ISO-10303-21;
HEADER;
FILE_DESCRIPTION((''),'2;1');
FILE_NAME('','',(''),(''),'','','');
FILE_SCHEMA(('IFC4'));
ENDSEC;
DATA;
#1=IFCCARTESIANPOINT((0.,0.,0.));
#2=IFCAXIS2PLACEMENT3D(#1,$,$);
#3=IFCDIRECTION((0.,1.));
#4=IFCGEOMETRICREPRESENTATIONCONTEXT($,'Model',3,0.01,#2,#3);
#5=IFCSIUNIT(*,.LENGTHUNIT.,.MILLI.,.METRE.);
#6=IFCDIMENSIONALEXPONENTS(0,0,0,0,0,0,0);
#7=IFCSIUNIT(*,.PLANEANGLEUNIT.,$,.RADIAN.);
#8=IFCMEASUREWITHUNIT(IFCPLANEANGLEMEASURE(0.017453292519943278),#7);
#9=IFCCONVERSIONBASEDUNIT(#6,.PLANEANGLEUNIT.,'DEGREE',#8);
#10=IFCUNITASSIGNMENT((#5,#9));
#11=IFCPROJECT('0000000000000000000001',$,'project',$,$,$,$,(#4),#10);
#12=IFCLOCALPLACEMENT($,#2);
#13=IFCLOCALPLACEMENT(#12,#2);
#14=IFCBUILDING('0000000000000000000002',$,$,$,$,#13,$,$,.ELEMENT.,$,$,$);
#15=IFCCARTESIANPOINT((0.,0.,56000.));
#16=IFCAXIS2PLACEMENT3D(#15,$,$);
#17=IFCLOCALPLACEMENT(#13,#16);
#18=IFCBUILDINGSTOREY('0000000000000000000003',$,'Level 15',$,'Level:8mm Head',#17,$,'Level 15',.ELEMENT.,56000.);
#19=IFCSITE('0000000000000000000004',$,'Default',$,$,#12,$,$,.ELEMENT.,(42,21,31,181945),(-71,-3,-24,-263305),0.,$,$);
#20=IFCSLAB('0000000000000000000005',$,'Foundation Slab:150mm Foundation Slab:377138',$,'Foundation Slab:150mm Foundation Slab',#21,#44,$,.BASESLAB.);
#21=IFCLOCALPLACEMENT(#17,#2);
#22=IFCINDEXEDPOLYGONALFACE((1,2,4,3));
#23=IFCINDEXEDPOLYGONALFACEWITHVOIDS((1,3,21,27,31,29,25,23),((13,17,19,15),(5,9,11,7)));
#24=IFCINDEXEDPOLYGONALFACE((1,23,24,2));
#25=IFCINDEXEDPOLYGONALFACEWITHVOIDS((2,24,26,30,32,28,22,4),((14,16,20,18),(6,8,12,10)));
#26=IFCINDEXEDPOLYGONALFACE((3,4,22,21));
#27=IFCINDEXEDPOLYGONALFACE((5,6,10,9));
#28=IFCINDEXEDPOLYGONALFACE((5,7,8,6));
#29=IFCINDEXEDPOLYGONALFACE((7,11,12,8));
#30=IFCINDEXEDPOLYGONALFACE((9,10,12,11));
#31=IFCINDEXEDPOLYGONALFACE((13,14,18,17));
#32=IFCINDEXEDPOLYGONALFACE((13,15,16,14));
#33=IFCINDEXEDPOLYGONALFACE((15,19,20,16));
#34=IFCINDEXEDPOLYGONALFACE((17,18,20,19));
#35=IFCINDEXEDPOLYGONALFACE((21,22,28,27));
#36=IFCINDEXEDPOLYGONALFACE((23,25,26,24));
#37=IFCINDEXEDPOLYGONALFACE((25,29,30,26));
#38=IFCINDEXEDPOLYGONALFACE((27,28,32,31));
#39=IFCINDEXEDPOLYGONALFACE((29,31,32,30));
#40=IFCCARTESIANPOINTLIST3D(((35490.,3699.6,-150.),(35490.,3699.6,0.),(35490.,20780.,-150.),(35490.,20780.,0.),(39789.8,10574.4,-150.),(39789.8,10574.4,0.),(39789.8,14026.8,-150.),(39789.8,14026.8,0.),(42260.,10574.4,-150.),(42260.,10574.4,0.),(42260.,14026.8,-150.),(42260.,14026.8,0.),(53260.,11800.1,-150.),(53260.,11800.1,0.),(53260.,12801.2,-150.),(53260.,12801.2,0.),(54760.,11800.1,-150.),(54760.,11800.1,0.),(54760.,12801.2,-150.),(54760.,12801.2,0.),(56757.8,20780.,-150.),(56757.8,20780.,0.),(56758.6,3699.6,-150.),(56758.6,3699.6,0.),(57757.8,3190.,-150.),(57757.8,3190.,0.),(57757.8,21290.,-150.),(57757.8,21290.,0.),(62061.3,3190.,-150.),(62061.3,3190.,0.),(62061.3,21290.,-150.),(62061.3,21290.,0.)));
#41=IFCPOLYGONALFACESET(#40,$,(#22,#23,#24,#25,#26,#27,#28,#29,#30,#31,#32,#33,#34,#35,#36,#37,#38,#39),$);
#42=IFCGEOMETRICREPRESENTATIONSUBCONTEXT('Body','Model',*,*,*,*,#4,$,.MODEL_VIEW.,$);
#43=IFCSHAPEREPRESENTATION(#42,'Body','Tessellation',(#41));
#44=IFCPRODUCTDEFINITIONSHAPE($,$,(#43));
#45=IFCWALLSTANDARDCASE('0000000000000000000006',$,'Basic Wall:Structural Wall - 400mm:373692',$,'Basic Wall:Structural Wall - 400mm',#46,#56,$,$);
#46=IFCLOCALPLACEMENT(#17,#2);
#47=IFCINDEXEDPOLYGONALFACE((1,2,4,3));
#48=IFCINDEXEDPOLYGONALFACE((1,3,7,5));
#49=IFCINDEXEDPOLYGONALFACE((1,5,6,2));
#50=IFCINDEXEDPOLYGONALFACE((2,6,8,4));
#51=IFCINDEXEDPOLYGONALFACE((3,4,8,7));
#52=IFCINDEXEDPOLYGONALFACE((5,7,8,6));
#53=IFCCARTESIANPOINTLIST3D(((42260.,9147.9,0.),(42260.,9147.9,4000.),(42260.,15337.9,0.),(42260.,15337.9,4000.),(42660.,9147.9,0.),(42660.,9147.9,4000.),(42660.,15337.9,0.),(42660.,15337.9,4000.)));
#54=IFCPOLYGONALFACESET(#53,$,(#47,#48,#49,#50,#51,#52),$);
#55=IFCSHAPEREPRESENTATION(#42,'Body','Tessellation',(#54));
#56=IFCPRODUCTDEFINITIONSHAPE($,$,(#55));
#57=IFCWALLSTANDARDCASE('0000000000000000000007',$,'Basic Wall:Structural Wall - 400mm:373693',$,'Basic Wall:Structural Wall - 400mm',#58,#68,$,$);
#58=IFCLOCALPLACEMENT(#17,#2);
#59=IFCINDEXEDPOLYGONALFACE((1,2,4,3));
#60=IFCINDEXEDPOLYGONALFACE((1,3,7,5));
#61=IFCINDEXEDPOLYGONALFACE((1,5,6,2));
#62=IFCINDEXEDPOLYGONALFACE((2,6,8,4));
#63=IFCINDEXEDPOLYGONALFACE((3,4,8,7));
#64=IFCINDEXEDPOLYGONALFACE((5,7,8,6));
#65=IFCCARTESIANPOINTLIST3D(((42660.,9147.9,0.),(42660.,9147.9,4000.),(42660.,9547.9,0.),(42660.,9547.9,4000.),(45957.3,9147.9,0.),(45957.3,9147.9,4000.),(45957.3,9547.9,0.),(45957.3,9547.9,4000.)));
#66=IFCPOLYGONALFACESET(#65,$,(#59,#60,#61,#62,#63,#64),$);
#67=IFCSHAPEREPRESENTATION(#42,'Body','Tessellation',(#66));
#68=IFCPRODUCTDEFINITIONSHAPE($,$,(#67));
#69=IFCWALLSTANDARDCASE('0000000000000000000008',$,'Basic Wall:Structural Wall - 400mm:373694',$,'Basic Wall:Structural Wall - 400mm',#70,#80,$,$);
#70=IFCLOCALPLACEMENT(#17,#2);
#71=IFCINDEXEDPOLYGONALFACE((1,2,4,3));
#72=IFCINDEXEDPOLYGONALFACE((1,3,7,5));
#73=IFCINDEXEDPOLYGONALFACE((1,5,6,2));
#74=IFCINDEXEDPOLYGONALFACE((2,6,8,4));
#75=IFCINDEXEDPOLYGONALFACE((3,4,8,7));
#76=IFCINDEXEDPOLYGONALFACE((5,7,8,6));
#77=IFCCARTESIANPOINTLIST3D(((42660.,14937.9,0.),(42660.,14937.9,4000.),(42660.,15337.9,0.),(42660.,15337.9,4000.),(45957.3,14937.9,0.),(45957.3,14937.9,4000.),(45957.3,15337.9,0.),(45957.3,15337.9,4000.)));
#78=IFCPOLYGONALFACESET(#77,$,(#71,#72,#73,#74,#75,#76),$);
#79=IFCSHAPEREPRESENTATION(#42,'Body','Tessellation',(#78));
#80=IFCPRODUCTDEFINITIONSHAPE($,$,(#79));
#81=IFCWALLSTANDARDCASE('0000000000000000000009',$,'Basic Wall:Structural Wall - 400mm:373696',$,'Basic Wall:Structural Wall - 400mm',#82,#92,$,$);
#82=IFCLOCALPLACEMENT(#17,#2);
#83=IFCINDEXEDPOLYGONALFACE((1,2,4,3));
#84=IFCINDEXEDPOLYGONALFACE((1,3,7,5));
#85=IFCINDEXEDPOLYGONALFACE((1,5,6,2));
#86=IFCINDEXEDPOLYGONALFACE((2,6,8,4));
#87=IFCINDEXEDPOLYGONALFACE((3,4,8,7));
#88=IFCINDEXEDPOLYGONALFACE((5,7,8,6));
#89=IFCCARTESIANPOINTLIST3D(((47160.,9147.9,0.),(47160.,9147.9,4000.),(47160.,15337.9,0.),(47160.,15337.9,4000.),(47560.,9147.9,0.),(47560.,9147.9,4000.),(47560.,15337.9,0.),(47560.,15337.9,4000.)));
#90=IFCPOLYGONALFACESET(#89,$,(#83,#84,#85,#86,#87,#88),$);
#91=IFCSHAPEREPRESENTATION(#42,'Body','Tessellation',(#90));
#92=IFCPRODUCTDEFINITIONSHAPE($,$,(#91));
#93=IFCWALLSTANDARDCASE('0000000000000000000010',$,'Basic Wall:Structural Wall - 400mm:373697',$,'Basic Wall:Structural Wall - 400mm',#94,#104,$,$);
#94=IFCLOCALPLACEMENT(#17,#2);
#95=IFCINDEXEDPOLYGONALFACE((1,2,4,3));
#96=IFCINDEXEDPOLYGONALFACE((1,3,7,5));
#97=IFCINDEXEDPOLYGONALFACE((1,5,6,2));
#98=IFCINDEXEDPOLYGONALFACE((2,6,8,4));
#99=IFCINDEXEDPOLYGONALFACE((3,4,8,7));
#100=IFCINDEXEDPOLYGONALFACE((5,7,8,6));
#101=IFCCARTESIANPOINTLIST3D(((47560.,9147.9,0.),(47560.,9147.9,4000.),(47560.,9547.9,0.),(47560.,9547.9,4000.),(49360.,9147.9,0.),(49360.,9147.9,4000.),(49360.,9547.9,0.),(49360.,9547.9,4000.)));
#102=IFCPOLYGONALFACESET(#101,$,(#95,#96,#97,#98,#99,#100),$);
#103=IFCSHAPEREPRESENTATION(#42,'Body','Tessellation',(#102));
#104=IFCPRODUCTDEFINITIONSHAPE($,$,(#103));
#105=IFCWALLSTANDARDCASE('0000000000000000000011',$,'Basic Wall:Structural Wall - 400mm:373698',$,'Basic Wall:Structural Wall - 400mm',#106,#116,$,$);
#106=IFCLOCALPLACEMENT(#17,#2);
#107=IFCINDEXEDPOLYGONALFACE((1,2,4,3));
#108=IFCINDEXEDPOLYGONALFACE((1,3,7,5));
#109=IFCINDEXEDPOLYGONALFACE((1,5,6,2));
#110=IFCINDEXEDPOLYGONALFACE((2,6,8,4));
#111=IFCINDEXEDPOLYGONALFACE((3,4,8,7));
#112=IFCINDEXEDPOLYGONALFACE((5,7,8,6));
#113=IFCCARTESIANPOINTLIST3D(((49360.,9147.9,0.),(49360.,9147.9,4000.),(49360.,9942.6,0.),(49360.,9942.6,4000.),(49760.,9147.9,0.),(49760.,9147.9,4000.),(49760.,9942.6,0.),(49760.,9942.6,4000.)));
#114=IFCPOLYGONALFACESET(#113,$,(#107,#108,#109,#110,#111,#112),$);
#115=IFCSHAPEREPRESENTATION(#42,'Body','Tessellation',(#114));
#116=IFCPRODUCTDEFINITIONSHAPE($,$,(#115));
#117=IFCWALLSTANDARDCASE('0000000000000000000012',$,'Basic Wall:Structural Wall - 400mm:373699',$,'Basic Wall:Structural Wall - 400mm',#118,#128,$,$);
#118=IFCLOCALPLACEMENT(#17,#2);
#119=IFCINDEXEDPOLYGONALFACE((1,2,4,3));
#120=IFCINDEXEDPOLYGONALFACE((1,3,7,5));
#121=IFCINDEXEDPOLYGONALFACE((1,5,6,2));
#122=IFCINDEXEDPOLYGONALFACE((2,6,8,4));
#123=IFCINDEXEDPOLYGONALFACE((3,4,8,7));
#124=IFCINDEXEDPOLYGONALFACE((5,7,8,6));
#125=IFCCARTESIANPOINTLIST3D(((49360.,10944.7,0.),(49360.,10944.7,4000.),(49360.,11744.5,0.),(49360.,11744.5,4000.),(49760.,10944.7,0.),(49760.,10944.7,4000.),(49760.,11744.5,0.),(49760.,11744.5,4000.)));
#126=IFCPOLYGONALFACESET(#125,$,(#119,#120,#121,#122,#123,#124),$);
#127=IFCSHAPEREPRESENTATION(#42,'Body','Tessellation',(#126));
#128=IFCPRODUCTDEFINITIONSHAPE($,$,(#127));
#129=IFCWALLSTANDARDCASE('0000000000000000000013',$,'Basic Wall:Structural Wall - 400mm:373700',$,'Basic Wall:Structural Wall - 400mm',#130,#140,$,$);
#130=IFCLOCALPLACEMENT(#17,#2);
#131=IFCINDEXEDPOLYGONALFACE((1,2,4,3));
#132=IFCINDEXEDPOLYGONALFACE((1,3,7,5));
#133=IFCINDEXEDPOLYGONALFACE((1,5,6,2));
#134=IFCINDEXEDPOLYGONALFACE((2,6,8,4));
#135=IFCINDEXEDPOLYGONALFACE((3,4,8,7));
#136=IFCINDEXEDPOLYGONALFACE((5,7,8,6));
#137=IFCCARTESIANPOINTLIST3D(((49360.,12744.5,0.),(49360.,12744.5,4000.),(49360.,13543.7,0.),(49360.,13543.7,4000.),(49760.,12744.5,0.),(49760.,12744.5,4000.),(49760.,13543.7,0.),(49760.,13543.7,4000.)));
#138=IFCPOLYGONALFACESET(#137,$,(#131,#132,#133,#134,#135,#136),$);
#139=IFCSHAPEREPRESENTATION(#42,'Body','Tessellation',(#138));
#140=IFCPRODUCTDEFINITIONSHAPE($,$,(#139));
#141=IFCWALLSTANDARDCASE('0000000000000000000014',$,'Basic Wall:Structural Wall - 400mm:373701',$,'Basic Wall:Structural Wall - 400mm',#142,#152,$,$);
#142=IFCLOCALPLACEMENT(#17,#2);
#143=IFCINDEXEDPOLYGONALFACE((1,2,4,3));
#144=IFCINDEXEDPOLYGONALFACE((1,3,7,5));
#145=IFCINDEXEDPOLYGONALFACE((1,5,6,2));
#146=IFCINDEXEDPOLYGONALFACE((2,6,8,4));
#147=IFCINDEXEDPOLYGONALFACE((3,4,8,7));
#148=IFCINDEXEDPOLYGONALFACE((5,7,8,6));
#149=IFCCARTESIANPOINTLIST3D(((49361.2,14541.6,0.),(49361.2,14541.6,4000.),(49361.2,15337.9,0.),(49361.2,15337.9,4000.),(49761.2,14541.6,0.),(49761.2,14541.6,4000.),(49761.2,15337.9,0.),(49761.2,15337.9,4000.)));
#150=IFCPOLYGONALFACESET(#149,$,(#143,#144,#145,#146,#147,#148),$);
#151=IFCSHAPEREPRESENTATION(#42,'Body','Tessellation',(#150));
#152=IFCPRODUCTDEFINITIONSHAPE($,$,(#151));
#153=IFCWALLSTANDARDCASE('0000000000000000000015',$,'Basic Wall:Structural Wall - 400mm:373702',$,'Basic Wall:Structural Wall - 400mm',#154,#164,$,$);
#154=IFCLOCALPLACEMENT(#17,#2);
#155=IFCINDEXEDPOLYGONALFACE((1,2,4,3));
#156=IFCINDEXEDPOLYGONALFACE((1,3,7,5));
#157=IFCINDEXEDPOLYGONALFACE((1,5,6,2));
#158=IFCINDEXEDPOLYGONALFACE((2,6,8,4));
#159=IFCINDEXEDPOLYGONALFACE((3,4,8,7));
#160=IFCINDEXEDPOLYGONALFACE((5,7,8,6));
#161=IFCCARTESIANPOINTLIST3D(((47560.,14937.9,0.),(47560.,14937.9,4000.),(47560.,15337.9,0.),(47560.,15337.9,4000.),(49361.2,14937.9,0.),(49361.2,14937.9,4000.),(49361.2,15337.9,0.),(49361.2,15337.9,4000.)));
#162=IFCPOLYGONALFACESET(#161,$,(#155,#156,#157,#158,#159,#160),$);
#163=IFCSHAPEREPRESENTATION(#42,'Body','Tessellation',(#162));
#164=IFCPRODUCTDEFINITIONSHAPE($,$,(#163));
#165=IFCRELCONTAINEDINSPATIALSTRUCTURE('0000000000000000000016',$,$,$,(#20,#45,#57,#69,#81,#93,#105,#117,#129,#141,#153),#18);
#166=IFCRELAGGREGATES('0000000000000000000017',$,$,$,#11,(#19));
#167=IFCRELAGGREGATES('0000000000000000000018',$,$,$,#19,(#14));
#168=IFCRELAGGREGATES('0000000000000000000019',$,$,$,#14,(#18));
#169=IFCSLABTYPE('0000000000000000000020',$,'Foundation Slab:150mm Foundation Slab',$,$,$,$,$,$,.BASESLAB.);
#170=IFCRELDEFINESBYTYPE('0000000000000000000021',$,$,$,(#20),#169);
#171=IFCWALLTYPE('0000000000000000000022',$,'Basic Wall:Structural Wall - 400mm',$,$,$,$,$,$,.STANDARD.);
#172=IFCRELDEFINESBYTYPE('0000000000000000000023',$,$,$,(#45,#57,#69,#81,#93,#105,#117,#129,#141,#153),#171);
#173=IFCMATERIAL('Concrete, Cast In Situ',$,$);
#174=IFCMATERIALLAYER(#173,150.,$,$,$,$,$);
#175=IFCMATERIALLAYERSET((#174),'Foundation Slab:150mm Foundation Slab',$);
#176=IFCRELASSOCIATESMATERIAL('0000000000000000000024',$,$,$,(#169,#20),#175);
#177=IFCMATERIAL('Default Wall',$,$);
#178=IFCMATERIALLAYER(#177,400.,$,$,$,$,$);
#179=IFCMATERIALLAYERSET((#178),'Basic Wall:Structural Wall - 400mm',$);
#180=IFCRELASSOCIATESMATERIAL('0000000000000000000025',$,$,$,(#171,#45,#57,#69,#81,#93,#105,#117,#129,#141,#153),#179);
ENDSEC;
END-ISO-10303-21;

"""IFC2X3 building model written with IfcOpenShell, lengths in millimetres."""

from ifc_helpers import new_model, entity, si_unit, converted_unit, direction, frame, frame_2d, origin, place, context, subcontext, project, spatial, polyline, rectangle, outline, extrude, boolean, material, layer, layer_set, layer_usage, type_object, element, save


model = new_model("IFC2X3")

# Units and contexts
model_context = context("Model", 3, precision=0.01, world=origin(), true_north=direction((0.0, 1.0)))
body_context = subcontext(model_context, "Body", "Model", "MODEL_VIEW")
ifc_project = project(units=[si_unit("LENGTHUNIT", "METRE", prefix="MILLI"), converted_unit("PLANEANGLEUNIT", "DEGREE", entity("IfcPlaneAngleMeasure", 0.017453292519943278), si_unit("PLANEANGLEUNIT", "RADIAN"), dimensions=[0, 0, 0, 0, 0, 0, 0])], contexts=[model_context])

# Site, building, storey
site_placement = place(None, origin())
site = spatial("IfcSite", under=ifc_project, at=site_placement, Name="Default", CompositionType="ELEMENT", RefLatitude=(42, 21, 31, 181945), RefLongitude=(-71, -3, -24, -263305), RefElevation=0.0)
building_placement = place(site_placement, origin())
building = spatial("IfcBuilding", under=site, at=building_placement, CompositionType="ELEMENT")
storey_placement = place(building_placement, frame((0.0, 0.0, 56000.0)))
storey = spatial("IfcBuildingStorey", under=building, at=storey_placement, Name="Level 15", ObjectType="Level:8mm Head", LongName="Level 15", CompositionType="ELEMENT", Elevation=56000.0)

# Slab, openings
ifc_material_1 = material(Name="Concrete, Cast In Situ")
ifc_layer_1 = layer(ifc_material_1, 150.0)
ifc_layer_set_1 = layer_set([ifc_layer_1], Name="Foundation Slab:150mm Foundation Slab")
ifc_layer_usage_1 = layer_usage(ifc_layer_set_1, "AXIS3", "POSITIVE", 0.0)
slab_type = type_object("IfcSlabType", Name="Foundation Slab:150mm Foundation Slab", PredefinedType="BASESLAB", material=ifc_layer_set_1)
slab_placement = place(storey_placement, origin())
slab = element("IfcSlab", 1, at=slab_placement, inside=storey, type_object=slab_type, material=ifc_layer_usage_1, Name="Foundation Slab:150mm Foundation Slab:377138", ObjectType="Foundation Slab:150mm Foundation Slab", PredefinedType="BASESLAB", context=body_context, shape_type="CSG", body=[
    boolean("DIFFERENCE", boolean("DIFFERENCE", extrude(outline(polyline([(-8540.3, -17526.8), (8540.1, -17526.8), (8540.1, 3741.0), (9050.1, 4741.0), (9050.1, 9044.5), (-9049.9, 9044.5), (-9049.9, 4741.0), (-8540.3, 3741.8), (-8540.3, -17526.8)])), frame((53016.8, 12239.9, 0.0), z_axis=(0.0, 0.0, -1.0), x_axis=(0.0, 1.0, 0.0)), (0.0, 0.0, 1.0), 150.0), extrude(rectangle(XDim=3452.5, YDim=2470.2, at=frame_2d((0.0, 0.0), x_axis=(1.0, 0.0))), frame((41024.9, 12300.6, -150.0), z_axis=(0.0, 0.0, 1.0), x_axis=(0.0, 1.0, 0.0)), (0.0, 0.0, 1.0), 150.0)), extrude(rectangle(XDim=1001.2, YDim=1500.1, at=frame_2d((0.0, 0.0), x_axis=(1.0, 0.0))), frame((54010.0, 12300.6, -150.0), z_axis=(0.0, 0.0, 1.0), x_axis=(0.0, 1.0, 0.0)), (0.0, 0.0, 1.0), 150.0)),
])
opening_1_placement = place(slab_placement, origin())
element("IfcOpeningElement", 2, at=opening_1_placement, cuts=slab, ObjectType="Opening", context=body_context, shape_type="SweptSolid", body=[
    extrude(rectangle(XDim=3452.5, YDim=2470.2, at=frame_2d((41024.9, 12300.6), x_axis=(0.0, -1.0))), origin(), (0.0, 0.0, -1.0), 150.0),
])
opening_2_placement = place(slab_placement, origin())
element("IfcOpeningElement", 3, at=opening_2_placement, cuts=slab, ObjectType="Opening", context=body_context, shape_type="SweptSolid", body=[
    extrude(rectangle(XDim=1500.1, YDim=1001.2, at=frame_2d((54010.0, 12300.6), x_axis=(-1.0, 0.0))), origin(), (0.0, 0.0, -1.0), 150.0),
])

# Walls
ifc_material_2 = material(Name="Default Wall")
ifc_layer_2 = layer(ifc_material_2, 400.0)
ifc_layer_set_2 = layer_set([ifc_layer_2], Name="Basic Wall:Structural Wall - 400mm")
ifc_layer_usage_2 = layer_usage(ifc_layer_set_2, "AXIS2", "POSITIVE", -200.0)
wall_type_1 = type_object("IfcWallType", Name="Basic Wall:Structural Wall - 400mm", PredefinedType="STANDARD", material=ifc_layer_set_2)
wall_1_placement = place(storey_placement, frame((42460.0, 15337.9, 0.0), z_axis=(0.0, 0.0, 1.0), x_axis=(0.0, -1.0, 0.0)))
element("IfcWallStandardCase", 4, at=wall_1_placement, inside=storey, type_object=wall_type_1, material=ifc_layer_usage_2, Name="Basic Wall:Structural Wall - 400mm:373692", ObjectType="Basic Wall:Structural Wall - 400mm", context=body_context, shape_type="SweptSolid", body=[
    extrude(rectangle(XDim=6190.0, YDim=400.0, at=frame_2d((3095.0, 0.0), x_axis=(-1.0, 0.0))), origin(), (0.0, 0.0, 1.0), 4000.0),
])
ifc_layer_usage_3 = layer_usage(ifc_layer_set_2, "AXIS2", "POSITIVE", -200.0)
wall_2_placement = place(storey_placement, frame((42660.0, 9347.9, 0.0)))
element("IfcWallStandardCase", 5, at=wall_2_placement, inside=storey, type_object=wall_type_1, material=ifc_layer_usage_3, Name="Basic Wall:Structural Wall - 400mm:373693", ObjectType="Basic Wall:Structural Wall - 400mm", context=body_context, shape_type="SweptSolid", body=[
    extrude(rectangle(XDim=3297.3, YDim=400.0, at=frame_2d((1648.6, 0.0), x_axis=(-1.0, 0.0))), origin(), (0.0, 0.0, 1.0), 4000.0),
])
ifc_layer_usage_4 = layer_usage(ifc_layer_set_2, "AXIS2", "POSITIVE", -200.0)
wall_3_placement = place(storey_placement, frame((45957.3, 15137.9, 0.0), z_axis=(0.0, 0.0, 1.0), x_axis=(-1.0, 0.0, 0.0)))
element("IfcWallStandardCase", 6, at=wall_3_placement, inside=storey, type_object=wall_type_1, material=ifc_layer_usage_4, Name="Basic Wall:Structural Wall - 400mm:373694", ObjectType="Basic Wall:Structural Wall - 400mm", context=body_context, shape_type="SweptSolid", body=[
    extrude(rectangle(XDim=3297.3, YDim=400.0, at=frame_2d((1648.6, 0.0), x_axis=(-1.0, 0.0))), origin(), (0.0, 0.0, 1.0), 4000.0),
])
ifc_layer_usage_5 = layer_usage(ifc_layer_set_2, "AXIS2", "POSITIVE", -200.0)
wall_4_placement = place(storey_placement, frame((47360.0, 15337.9, 0.0), z_axis=(0.0, 0.0, 1.0), x_axis=(0.0, -1.0, 0.0)))
element("IfcWallStandardCase", 7, at=wall_4_placement, inside=storey, type_object=wall_type_1, material=ifc_layer_usage_5, Name="Basic Wall:Structural Wall - 400mm:373696", ObjectType="Basic Wall:Structural Wall - 400mm", context=body_context, shape_type="SweptSolid", body=[
    extrude(rectangle(XDim=6190.0, YDim=400.0, at=frame_2d((3095.0, 0.0), x_axis=(-1.0, 0.0))), origin(), (0.0, 0.0, 1.0), 4000.0),
])
ifc_layer_usage_6 = layer_usage(ifc_layer_set_2, "AXIS2", "POSITIVE", -200.0)
wall_5_placement = place(storey_placement, frame((47560.0, 9347.9, 0.0)))
element("IfcWallStandardCase", 8, at=wall_5_placement, inside=storey, type_object=wall_type_1, material=ifc_layer_usage_6, Name="Basic Wall:Structural Wall - 400mm:373697", ObjectType="Basic Wall:Structural Wall - 400mm", context=body_context, shape_type="SweptSolid", body=[
    extrude(rectangle(XDim=1800.0, YDim=400.0, at=frame_2d((900.0, 0.0), x_axis=(-1.0, 0.0))), origin(), (0.0, 0.0, 1.0), 4000.0),
])
ifc_layer_usage_7 = layer_usage(ifc_layer_set_2, "AXIS2", "NEGATIVE", 200.0)
wall_6_placement = place(storey_placement, frame((49560.0, 9147.9, 0.0), z_axis=(0.0, 0.0, 1.0), x_axis=(0.0, 1.0, 0.0)))
element("IfcWallStandardCase", 9, at=wall_6_placement, inside=storey, type_object=wall_type_1, material=ifc_layer_usage_7, Name="Basic Wall:Structural Wall - 400mm:373698", ObjectType="Basic Wall:Structural Wall - 400mm", context=body_context, shape_type="SweptSolid", body=[
    extrude(rectangle(XDim=794.7, YDim=400.0, at=frame_2d((397.3, 0.0), x_axis=(-1.0, 0.0))), origin(), (0.0, 0.0, 1.0), 4000.0),
])
ifc_layer_usage_8 = layer_usage(ifc_layer_set_2, "AXIS2", "POSITIVE", -200.0)
wall_7_placement = place(storey_placement, frame((49560.0, 10944.7, 0.0), z_axis=(0.0, 0.0, 1.0), x_axis=(0.0, 1.0, 0.0)))
element("IfcWallStandardCase", 10, at=wall_7_placement, inside=storey, type_object=wall_type_1, material=ifc_layer_usage_8, Name="Basic Wall:Structural Wall - 400mm:373699", ObjectType="Basic Wall:Structural Wall - 400mm", context=body_context, shape_type="SweptSolid", body=[
    extrude(rectangle(XDim=799.8, YDim=400.0, at=frame_2d((399.9, 0.0), x_axis=(-1.0, 0.0))), origin(), (0.0, 0.0, 1.0), 4000.0),
])
ifc_layer_usage_9 = layer_usage(ifc_layer_set_2, "AXIS2", "POSITIVE", -200.0)
wall_8_placement = place(storey_placement, frame((49560.0, 12744.5, 0.0), z_axis=(0.0, 0.0, 1.0), x_axis=(0.0, 1.0, 0.0)))
element("IfcWallStandardCase", 11, at=wall_8_placement, inside=storey, type_object=wall_type_1, material=ifc_layer_usage_9, Name="Basic Wall:Structural Wall - 400mm:373700", ObjectType="Basic Wall:Structural Wall - 400mm", context=body_context, shape_type="SweptSolid", body=[
    extrude(rectangle(XDim=799.2, YDim=400.0, at=frame_2d((399.6, 0.0), x_axis=(-1.0, 0.0))), origin(), (0.0, 0.0, 1.0), 4000.0),
])
ifc_layer_usage_10 = layer_usage(ifc_layer_set_2, "AXIS2", "POSITIVE", -200.0)
wall_9_placement = place(storey_placement, frame((49561.2, 14541.6, 0.0), z_axis=(0.0, 0.0, 1.0), x_axis=(0.0, 1.0, 0.0)))
element("IfcWallStandardCase", 12, at=wall_9_placement, inside=storey, type_object=wall_type_1, material=ifc_layer_usage_10, Name="Basic Wall:Structural Wall - 400mm:373701", ObjectType="Basic Wall:Structural Wall - 400mm", context=body_context, shape_type="SweptSolid", body=[
    extrude(rectangle(XDim=796.3, YDim=400.0, at=frame_2d((398.2, 0.0), x_axis=(-1.0, 0.0))), origin(), (0.0, 0.0, 1.0), 4000.0),
])
ifc_layer_usage_11 = layer_usage(ifc_layer_set_2, "AXIS2", "POSITIVE", -200.0)
wall_10_placement = place(storey_placement, frame((49361.2, 15137.9, 0.0), z_axis=(0.0, 0.0, 1.0), x_axis=(-1.0, 0.0, 0.0)))
element("IfcWallStandardCase", 13, at=wall_10_placement, inside=storey, type_object=wall_type_1, material=ifc_layer_usage_11, Name="Basic Wall:Structural Wall - 400mm:373702", ObjectType="Basic Wall:Structural Wall - 400mm", context=body_context, shape_type="SweptSolid", body=[
    extrude(rectangle(XDim=1801.2, YDim=400.0, at=frame_2d((900.6, 0.0), x_axis=(-1.0, 0.0))), origin(), (0.0, 0.0, 1.0), 4000.0),
])

save(model, "model.ifc")
